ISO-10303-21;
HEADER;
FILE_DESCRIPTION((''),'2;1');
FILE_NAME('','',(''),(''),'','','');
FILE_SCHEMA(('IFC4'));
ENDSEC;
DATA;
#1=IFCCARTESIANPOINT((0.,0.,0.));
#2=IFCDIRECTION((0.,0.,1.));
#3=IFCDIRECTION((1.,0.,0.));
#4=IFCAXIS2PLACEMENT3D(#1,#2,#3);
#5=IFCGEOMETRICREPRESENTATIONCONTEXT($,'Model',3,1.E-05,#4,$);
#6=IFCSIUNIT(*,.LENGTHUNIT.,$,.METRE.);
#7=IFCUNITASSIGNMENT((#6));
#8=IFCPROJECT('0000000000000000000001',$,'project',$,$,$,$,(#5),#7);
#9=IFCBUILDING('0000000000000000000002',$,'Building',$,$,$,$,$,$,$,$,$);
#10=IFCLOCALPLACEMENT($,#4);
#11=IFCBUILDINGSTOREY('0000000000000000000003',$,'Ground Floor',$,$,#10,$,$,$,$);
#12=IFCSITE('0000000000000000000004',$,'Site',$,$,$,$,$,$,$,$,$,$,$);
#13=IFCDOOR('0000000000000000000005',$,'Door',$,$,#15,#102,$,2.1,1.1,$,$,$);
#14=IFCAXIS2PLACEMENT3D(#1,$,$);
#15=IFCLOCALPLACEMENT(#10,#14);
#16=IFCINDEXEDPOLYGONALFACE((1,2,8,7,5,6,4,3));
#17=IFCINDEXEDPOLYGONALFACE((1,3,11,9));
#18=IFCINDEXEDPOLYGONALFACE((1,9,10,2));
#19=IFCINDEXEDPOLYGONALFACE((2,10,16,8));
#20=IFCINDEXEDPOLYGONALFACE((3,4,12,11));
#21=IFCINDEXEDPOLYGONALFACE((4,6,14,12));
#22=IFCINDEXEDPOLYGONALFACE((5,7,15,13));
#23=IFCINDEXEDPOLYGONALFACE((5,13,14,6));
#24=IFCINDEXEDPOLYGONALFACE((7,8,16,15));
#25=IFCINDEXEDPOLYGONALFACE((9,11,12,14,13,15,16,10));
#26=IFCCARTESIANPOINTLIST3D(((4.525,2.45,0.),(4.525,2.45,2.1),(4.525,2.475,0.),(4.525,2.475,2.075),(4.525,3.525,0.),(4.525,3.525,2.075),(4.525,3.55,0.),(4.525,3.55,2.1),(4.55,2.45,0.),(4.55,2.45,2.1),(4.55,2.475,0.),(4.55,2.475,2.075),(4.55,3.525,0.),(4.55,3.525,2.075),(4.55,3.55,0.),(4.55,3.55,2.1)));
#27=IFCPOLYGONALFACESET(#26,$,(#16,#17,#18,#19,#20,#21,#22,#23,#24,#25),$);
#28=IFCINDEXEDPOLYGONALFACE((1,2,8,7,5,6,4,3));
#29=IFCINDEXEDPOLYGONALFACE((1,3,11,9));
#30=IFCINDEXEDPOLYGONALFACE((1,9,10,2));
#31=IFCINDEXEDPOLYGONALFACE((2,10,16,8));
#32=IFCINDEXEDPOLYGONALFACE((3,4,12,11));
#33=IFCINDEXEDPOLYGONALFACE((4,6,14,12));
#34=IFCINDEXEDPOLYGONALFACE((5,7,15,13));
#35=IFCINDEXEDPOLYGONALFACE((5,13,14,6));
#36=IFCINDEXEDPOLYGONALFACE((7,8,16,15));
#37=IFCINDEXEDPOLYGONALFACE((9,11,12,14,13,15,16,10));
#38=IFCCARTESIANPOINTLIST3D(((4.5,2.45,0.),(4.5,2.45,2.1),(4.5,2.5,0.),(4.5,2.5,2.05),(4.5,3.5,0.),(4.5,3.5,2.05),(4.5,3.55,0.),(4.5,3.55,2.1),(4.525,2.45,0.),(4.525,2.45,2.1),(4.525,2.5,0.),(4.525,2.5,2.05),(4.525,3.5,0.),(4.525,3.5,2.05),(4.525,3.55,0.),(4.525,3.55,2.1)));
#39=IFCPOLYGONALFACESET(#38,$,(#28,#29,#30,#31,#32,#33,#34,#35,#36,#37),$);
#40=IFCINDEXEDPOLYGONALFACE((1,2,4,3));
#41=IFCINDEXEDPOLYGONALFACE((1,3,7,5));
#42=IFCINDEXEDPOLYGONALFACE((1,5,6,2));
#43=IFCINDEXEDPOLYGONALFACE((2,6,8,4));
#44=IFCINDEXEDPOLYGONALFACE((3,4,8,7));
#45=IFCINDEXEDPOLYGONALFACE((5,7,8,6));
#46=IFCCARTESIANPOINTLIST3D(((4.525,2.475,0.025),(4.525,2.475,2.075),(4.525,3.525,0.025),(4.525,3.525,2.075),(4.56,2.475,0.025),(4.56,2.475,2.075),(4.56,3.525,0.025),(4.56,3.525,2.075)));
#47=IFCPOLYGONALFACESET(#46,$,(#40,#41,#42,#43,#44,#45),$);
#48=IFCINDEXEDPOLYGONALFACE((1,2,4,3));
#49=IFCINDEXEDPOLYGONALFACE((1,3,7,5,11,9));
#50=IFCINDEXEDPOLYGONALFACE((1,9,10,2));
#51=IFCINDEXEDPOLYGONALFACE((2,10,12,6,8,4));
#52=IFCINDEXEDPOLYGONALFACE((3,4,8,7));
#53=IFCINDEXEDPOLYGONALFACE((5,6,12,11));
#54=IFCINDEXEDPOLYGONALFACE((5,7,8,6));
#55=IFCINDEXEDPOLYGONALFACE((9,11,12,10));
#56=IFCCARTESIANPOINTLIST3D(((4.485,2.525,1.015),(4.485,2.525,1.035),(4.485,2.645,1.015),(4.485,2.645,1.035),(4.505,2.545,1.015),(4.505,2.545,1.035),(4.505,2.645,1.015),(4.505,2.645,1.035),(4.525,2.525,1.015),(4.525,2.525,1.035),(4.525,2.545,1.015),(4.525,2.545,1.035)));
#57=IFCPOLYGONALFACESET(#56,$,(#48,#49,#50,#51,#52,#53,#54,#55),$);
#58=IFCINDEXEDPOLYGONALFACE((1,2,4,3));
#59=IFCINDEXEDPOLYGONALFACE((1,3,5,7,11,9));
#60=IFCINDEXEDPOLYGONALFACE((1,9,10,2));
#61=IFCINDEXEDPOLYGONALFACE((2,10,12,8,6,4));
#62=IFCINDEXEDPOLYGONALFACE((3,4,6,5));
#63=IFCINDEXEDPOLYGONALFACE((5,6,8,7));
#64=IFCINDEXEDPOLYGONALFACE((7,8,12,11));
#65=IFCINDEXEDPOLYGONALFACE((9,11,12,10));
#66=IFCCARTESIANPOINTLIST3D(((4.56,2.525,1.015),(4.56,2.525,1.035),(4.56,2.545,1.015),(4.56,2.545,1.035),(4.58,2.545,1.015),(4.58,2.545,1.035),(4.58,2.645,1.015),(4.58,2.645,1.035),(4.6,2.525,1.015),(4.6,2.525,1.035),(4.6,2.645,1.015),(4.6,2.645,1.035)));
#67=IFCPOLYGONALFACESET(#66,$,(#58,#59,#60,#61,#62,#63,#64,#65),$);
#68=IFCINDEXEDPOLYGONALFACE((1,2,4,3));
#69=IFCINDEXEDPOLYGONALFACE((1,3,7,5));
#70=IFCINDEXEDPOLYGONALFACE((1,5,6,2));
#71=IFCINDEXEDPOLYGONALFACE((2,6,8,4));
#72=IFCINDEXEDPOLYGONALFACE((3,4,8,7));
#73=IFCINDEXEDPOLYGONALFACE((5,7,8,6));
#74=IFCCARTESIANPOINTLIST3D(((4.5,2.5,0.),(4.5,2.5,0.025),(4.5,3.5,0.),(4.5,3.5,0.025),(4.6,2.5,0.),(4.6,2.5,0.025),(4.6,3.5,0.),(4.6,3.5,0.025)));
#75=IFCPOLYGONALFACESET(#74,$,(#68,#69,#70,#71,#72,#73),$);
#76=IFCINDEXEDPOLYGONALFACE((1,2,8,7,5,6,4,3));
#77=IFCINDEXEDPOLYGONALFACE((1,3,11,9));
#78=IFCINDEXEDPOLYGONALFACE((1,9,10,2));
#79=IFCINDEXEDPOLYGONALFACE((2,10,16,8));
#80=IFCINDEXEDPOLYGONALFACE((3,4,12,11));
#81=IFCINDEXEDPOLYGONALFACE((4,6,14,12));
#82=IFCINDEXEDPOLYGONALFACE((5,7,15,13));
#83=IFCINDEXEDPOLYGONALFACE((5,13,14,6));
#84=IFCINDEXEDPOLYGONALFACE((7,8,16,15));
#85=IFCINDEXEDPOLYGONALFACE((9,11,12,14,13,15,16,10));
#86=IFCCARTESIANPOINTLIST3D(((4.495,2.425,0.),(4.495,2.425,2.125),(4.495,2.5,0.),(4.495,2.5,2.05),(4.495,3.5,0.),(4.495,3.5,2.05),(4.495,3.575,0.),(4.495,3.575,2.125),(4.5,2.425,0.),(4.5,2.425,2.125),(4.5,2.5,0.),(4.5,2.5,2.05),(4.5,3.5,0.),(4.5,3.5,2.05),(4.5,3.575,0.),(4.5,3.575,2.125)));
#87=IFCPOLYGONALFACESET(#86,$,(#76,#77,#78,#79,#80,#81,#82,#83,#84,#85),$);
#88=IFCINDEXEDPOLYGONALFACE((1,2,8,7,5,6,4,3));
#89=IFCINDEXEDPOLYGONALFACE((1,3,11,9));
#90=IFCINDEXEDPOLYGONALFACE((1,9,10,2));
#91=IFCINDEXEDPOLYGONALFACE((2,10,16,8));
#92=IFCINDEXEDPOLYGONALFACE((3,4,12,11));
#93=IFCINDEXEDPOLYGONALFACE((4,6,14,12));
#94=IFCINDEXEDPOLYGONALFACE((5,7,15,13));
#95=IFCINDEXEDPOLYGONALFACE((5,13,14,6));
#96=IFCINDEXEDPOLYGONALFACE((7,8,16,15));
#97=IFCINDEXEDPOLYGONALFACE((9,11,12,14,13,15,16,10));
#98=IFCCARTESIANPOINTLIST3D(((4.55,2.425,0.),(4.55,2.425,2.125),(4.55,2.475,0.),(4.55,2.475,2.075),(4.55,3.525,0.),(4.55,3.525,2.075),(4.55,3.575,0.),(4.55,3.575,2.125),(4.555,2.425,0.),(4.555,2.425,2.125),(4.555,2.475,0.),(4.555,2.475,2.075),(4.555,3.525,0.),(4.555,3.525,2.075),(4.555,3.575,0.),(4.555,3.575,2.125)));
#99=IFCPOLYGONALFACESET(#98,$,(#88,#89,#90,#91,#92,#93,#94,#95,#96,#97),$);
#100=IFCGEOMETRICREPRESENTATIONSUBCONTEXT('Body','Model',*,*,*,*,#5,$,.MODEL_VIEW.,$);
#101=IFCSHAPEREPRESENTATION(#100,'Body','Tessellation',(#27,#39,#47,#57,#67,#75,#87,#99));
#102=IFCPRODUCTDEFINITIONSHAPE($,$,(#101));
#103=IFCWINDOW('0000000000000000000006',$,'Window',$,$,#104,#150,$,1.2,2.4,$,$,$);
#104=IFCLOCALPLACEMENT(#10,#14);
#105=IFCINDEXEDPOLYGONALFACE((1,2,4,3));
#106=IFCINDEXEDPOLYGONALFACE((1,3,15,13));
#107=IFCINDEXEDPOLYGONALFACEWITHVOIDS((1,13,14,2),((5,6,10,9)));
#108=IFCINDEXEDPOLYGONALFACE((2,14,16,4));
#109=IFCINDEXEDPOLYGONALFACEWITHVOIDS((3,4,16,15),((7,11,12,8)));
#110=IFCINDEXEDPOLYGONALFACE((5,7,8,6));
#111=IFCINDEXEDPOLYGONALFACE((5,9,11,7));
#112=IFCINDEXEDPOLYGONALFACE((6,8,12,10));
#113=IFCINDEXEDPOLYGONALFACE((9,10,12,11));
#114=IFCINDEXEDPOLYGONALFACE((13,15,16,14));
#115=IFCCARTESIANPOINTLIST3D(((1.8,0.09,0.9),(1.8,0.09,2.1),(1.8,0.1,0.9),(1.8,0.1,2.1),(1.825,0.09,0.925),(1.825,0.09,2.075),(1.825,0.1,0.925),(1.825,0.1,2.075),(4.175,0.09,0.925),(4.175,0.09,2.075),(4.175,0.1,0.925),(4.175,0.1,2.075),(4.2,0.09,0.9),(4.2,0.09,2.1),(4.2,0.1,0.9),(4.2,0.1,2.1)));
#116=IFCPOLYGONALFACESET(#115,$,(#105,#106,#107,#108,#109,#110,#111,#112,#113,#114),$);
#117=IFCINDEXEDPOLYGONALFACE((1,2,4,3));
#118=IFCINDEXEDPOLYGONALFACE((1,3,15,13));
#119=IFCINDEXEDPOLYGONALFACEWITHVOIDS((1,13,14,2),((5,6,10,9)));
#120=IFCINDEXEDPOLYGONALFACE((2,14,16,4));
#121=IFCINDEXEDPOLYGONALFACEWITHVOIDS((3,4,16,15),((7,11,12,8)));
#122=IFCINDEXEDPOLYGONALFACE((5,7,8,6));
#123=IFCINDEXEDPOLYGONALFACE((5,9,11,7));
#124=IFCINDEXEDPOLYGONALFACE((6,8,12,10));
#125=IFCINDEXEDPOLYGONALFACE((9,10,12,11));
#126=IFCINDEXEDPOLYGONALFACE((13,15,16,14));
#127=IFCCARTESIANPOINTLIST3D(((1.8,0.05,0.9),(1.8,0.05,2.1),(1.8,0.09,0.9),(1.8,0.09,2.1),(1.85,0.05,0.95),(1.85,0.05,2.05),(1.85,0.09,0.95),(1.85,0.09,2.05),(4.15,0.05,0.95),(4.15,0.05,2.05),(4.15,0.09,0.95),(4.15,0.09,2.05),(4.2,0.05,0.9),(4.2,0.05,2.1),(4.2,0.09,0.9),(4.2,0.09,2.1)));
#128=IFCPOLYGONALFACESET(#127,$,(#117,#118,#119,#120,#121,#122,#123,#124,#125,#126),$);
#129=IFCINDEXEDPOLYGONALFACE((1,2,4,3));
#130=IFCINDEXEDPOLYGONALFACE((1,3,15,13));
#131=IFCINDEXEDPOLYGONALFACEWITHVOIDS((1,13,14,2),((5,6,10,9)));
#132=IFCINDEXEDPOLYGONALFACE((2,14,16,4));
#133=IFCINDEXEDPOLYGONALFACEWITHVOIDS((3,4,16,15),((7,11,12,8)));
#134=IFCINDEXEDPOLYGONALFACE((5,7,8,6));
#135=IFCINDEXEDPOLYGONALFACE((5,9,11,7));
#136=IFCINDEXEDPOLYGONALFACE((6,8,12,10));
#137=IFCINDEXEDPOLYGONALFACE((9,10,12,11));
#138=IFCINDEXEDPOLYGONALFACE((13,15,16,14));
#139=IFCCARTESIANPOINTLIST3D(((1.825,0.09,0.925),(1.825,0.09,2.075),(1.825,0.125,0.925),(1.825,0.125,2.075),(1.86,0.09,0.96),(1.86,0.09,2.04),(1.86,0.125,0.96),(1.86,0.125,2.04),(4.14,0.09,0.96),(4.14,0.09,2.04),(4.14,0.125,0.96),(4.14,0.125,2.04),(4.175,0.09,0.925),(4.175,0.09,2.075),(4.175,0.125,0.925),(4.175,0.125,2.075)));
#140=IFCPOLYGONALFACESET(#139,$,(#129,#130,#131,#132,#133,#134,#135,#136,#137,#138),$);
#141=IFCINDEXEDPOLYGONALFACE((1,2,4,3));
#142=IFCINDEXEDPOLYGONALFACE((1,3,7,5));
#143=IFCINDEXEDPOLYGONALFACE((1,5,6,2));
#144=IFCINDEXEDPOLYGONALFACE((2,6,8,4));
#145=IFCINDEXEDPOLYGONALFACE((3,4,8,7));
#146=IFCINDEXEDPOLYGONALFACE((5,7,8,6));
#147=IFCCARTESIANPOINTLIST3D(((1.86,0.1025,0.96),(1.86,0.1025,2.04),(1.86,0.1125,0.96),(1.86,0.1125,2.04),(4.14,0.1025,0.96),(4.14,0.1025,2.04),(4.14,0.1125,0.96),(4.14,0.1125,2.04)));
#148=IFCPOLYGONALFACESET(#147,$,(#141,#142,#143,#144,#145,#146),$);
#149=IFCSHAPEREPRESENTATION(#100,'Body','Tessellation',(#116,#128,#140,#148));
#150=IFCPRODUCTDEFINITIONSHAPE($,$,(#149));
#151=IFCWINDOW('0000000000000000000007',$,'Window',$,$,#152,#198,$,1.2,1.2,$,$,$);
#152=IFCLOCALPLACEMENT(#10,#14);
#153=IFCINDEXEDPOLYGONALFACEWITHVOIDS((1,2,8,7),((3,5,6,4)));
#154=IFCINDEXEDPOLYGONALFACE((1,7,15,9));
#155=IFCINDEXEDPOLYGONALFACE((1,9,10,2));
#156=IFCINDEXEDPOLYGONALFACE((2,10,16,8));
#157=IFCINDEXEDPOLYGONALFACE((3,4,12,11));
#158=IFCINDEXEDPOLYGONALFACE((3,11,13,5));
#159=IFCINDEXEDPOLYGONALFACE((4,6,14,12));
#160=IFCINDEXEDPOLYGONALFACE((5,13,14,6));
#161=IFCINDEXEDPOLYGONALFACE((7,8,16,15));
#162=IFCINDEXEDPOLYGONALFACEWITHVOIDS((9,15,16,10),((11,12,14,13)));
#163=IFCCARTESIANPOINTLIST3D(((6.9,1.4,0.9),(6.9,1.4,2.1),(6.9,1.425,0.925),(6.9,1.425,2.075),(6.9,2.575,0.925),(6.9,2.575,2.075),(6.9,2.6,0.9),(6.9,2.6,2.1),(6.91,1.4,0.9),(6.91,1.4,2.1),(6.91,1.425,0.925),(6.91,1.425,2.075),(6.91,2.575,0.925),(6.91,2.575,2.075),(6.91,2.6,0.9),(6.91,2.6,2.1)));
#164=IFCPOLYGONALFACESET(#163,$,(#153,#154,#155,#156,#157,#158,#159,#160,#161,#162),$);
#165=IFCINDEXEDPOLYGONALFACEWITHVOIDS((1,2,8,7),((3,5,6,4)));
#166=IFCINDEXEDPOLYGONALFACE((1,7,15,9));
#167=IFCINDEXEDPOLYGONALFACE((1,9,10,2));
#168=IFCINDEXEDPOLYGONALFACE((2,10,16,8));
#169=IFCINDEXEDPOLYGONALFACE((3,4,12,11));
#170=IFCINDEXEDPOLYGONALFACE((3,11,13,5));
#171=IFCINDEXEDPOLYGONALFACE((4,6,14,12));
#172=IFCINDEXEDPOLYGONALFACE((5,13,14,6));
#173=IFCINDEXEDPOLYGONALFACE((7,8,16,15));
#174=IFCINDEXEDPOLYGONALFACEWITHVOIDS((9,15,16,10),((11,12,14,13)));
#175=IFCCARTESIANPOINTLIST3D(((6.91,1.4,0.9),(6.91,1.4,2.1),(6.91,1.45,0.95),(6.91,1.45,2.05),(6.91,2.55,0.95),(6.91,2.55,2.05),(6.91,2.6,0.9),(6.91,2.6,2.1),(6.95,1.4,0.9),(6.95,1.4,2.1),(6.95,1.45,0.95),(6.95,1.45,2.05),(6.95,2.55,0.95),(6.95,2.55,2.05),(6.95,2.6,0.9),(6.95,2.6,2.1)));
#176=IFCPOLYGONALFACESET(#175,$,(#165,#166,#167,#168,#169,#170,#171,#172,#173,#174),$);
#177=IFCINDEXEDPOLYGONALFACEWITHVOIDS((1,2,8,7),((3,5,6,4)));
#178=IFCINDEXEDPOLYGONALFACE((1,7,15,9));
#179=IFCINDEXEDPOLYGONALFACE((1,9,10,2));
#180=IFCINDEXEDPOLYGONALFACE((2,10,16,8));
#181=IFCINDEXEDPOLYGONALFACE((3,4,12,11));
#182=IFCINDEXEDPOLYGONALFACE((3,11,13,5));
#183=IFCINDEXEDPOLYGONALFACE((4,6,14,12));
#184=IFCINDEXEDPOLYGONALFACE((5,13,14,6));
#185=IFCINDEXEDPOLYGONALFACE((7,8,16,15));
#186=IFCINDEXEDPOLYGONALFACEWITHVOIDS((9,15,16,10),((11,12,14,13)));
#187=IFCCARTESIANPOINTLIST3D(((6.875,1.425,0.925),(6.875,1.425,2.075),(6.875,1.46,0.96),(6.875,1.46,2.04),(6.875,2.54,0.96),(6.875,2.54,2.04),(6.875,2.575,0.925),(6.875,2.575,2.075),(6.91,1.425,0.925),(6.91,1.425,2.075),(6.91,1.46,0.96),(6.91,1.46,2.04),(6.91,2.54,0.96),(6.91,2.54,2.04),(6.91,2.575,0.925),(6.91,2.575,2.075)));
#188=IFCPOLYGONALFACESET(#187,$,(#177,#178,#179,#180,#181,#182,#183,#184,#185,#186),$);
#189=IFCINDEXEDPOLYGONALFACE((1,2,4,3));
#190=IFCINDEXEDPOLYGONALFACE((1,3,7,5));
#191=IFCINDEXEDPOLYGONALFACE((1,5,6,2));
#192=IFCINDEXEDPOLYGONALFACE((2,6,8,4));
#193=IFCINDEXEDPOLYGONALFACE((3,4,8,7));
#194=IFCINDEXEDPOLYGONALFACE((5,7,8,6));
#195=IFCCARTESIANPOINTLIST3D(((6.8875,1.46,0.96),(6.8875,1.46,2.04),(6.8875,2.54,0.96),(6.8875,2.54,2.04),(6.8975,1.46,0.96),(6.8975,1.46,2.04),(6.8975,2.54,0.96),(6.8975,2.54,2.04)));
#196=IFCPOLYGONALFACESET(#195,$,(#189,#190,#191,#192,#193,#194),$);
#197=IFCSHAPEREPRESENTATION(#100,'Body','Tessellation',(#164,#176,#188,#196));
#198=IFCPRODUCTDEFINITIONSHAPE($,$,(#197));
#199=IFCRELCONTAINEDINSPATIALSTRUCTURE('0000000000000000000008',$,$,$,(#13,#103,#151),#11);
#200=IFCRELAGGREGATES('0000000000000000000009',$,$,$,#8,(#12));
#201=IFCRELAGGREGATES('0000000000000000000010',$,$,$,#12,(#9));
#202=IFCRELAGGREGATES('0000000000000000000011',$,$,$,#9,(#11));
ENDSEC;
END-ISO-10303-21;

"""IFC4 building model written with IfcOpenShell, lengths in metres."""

from ifc_helpers import new_model, si_unit, frame, origin_with_axes, place, context, subcontext, project, spatial, line, indexed_curve, outline, extrude, element, save


model = new_model("IFC4")

# Units and contexts
model_context = context("Model", 3, precision=1e-05, world=origin_with_axes())
body_context = subcontext(model_context, "Body", "Model", "MODEL_VIEW")
ifc_project = project(units=[si_unit("LENGTHUNIT", "METRE")], contexts=[model_context])

# Site, building, storey
site = spatial("IfcSite", under=ifc_project, Name="Site")
building = spatial("IfcBuilding", under=site, Name="Building")
storey_placement = place(None, origin_with_axes())
storey = spatial("IfcBuildingStorey", under=building, at=storey_placement, Name="Ground Floor")

# Door
door_1_placement = place(storey_placement, frame((4.5, 3.55, 0.0), z_axis=(0.0, 0.0, 1.0), x_axis=(0.0, -1.0, 0.0)))
element("IfcDoor", 1, at=door_1_placement, inside=storey, Name="Door", OverallHeight=2.1, OverallWidth=1.1, context=body_context, shape_type="SweptSolid", body=[
    extrude(outline(indexed_curve([(0.0, 0.0), (0.0, 2.1), (1.1, 2.1), (1.1, 0.0), (1.075, 0.0), (1.075, 2.075), (0.025, 2.075), (0.025, 0.0)], segments=[line(1, 2, 3, 4, 5, 6, 7, 8, 1)])), frame((0.0, 0.025, 0.0), z_axis=(0.0, -1.0, 0.0), x_axis=(1.0, 0.0, 0.0)), (0.0, 0.0, -1.0), 0.025),
    extrude(outline(indexed_curve([(0.0, 0.0), (0.0, 2.1), (1.1, 2.1), (1.1, 0.0), (1.05, 0.0), (1.05, 2.05), (0.05, 2.05), (0.05, 0.0)], segments=[line(1, 2, 3, 4, 5, 6, 7, 8, 1)])), frame((0.0, 0.0, 0.0), z_axis=(0.0, -1.0, 0.0), x_axis=(1.0, 0.0, 0.0)), (0.0, 0.0, -1.0), 0.025),
    extrude(outline(indexed_curve([(0.0, 0.0), (1.05, 0.0), (1.05, 0.035), (0.0, 0.035)], segments=[line(1, 2, 3, 4, 1)])), frame((0.025, 0.025, 0.025), z_axis=(0.0, 0.0, 1.0), x_axis=(1.0, 0.0, 0.0)), (0.0, 0.0, 1.0), 2.05),
    extrude(outline(indexed_curve([(0.0, 0.0), (0.0, -0.04), (-0.12, -0.04), (-0.12, -0.02), (-0.02, -0.02), (-0.02, 0.0)], segments=[line(1, 2, 3, 4, 5, 6, 1)])), frame((1.025, 0.025, 1.015), z_axis=(0.0, 0.0, 1.0), x_axis=(1.0, 0.0, 0.0)), (0.0, 0.0, 1.0), 0.02),
    extrude(outline(indexed_curve([(0.0, 0.0), (0.0, 0.04), (-0.12, 0.04), (-0.12, 0.02), (-0.02, 0.02), (-0.02, 0.0)], segments=[line(1, 2, 3, 4, 5, 6, 1)])), frame((1.025, 0.06, 1.015), z_axis=(0.0, 0.0, 1.0), x_axis=(1.0, 0.0, 0.0)), (0.0, 0.0, 1.0), 0.02),
    extrude(outline(indexed_curve([(0.0, 0.0), (1.0, 0.0), (1.0, 0.1), (0.0, 0.1)], segments=[line(1, 2, 3, 4, 1)])), frame((0.05, 0.0, 0.0), z_axis=(0.0, 0.0, 1.0), x_axis=(1.0, 0.0, 0.0)), (0.0, 0.0, 1.0), 0.025),
    extrude(outline(indexed_curve([(0.0, 0.0), (0.0, 2.125), (1.15, 2.125), (1.15, 0.0), (1.075, 0.0), (1.075, 2.05), (0.075, 2.05), (0.075, 0.0)], segments=[line(1, 2, 3, 4, 5, 6, 7, 8, 1)])), frame((-0.025, -0.005, 0.0), z_axis=(0.0, -1.0, 0.0), x_axis=(1.0, 0.0, 0.0)), (0.0, 0.0, -1.0), 0.005),
    extrude(outline(indexed_curve([(0.0, 0.0), (0.0, 2.125), (1.15, 2.125), (1.15, 0.0), (1.1, 0.0), (1.1, 2.075), (0.05, 2.075), (0.05, 0.0)], segments=[line(1, 2, 3, 4, 5, 6, 7, 8, 1)])), frame((-0.025, 0.05, 0.0), z_axis=(0.0, -1.0, 0.0), x_axis=(1.0, 0.0, 0.0)), (0.0, 0.0, -1.0), 0.005),
])

# Windows
window_1_placement = place(storey_placement, frame((1.8, 0.0, 0.9), z_axis=(0.0, 0.0, 1.0), x_axis=(1.0, 0.0, 0.0)))
element("IfcWindow", 2, at=window_1_placement, inside=storey, Name="Window", OverallHeight=1.2, OverallWidth=2.4, context=body_context, shape_type="SweptSolid", body=[
    extrude(outline(indexed_curve([(0.0, 0.0), (2.4, 0.0), (2.4, 1.2), (0.0, 1.2)], segments=[line(1, 2, 3, 4, 1)]), holes=[indexed_curve([(0.025, 0.025), (2.375, 0.025), (2.375, 1.175), (0.025, 1.175)], segments=[line(1, 2, 3, 4, 1)])]), frame((0.0, 0.09, 0.0), z_axis=(0.0, -1.0, 0.0), x_axis=(1.0, 0.0, 0.0)), (0.0, 0.0, -1.0), 0.01),
    extrude(outline(indexed_curve([(0.0, 0.0), (2.4, 0.0), (2.4, 1.2), (0.0, 1.2)], segments=[line(1, 2, 3, 4, 1)]), holes=[indexed_curve([(0.05, 0.05), (2.35, 0.05), (2.35, 1.15), (0.05, 1.15)], segments=[line(1, 2, 3, 4, 1)])]), frame((0.0, 0.05, 0.0), z_axis=(0.0, -1.0, 0.0), x_axis=(1.0, 0.0, 0.0)), (0.0, 0.0, -1.0), 0.04),
    extrude(outline(indexed_curve([(0.0, 0.0), (2.35, 0.0), (2.35, 1.15), (0.0, 1.15)], segments=[line(1, 2, 3, 4, 1)]), holes=[indexed_curve([(0.035, 0.035), (2.315, 0.035), (2.315, 1.115), (0.035, 1.115)], segments=[line(1, 2, 3, 4, 1)])]), frame((0.025, 0.09, 0.025), z_axis=(0.0, -1.0, 0.0), x_axis=(1.0, 0.0, 0.0)), (0.0, 0.0, -1.0), 0.035),
    extrude(outline(indexed_curve([(0.035, 0.035), (2.315, 0.035), (2.315, 1.115), (0.035, 1.115)], segments=[line(1, 2, 3, 4, 1)])), frame((0.025, 0.1025, 0.025), z_axis=(0.0, -1.0, 0.0), x_axis=(1.0, 0.0, 0.0)), (0.0, 0.0, -1.0), 0.01),
])
window_2_placement = place(storey_placement, frame((7.0, 1.4, 0.9), z_axis=(0.0, 0.0, 1.0), x_axis=(0.0, 1.0, 0.0)))
element("IfcWindow", 3, at=window_2_placement, inside=storey, Name="Window", OverallHeight=1.2, OverallWidth=1.2, context=body_context, shape_type="SweptSolid", body=[
    extrude(outline(indexed_curve([(0.0, 0.0), (1.2, 0.0), (1.2, 1.2), (0.0, 1.2)], segments=[line(1, 2, 3, 4, 1)]), holes=[indexed_curve([(0.025, 0.025), (1.175, 0.025), (1.175, 1.175), (0.025, 1.175)], segments=[line(1, 2, 3, 4, 1)])]), frame((0.0, 0.09, 0.0), z_axis=(0.0, -1.0, 0.0), x_axis=(1.0, 0.0, 0.0)), (0.0, 0.0, -1.0), 0.01),
    extrude(outline(indexed_curve([(0.0, 0.0), (1.2, 0.0), (1.2, 1.2), (0.0, 1.2)], segments=[line(1, 2, 3, 4, 1)]), holes=[indexed_curve([(0.05, 0.05), (1.15, 0.05), (1.15, 1.15), (0.05, 1.15)], segments=[line(1, 2, 3, 4, 1)])]), frame((0.0, 0.05, 0.0), z_axis=(0.0, -1.0, 0.0), x_axis=(1.0, 0.0, 0.0)), (0.0, 0.0, -1.0), 0.04),
    extrude(outline(indexed_curve([(0.0, 0.0), (1.15, 0.0), (1.15, 1.15), (0.0, 1.15)], segments=[line(1, 2, 3, 4, 1)]), holes=[indexed_curve([(0.035, 0.035), (1.115, 0.035), (1.115, 1.115), (0.035, 1.115)], segments=[line(1, 2, 3, 4, 1)])]), frame((0.025, 0.09, 0.025), z_axis=(0.0, -1.0, 0.0), x_axis=(1.0, 0.0, 0.0)), (0.0, 0.0, -1.0), 0.035),
    extrude(outline(indexed_curve([(0.035, 0.035), (1.115, 0.035), (1.115, 1.115), (0.035, 1.115)], segments=[line(1, 2, 3, 4, 1)])), frame((0.025, 0.1025, 0.025), z_axis=(0.0, -1.0, 0.0), x_axis=(1.0, 0.0, 0.0)), (0.0, 0.0, -1.0), 0.01),
])

save(model, "model.ifc")
